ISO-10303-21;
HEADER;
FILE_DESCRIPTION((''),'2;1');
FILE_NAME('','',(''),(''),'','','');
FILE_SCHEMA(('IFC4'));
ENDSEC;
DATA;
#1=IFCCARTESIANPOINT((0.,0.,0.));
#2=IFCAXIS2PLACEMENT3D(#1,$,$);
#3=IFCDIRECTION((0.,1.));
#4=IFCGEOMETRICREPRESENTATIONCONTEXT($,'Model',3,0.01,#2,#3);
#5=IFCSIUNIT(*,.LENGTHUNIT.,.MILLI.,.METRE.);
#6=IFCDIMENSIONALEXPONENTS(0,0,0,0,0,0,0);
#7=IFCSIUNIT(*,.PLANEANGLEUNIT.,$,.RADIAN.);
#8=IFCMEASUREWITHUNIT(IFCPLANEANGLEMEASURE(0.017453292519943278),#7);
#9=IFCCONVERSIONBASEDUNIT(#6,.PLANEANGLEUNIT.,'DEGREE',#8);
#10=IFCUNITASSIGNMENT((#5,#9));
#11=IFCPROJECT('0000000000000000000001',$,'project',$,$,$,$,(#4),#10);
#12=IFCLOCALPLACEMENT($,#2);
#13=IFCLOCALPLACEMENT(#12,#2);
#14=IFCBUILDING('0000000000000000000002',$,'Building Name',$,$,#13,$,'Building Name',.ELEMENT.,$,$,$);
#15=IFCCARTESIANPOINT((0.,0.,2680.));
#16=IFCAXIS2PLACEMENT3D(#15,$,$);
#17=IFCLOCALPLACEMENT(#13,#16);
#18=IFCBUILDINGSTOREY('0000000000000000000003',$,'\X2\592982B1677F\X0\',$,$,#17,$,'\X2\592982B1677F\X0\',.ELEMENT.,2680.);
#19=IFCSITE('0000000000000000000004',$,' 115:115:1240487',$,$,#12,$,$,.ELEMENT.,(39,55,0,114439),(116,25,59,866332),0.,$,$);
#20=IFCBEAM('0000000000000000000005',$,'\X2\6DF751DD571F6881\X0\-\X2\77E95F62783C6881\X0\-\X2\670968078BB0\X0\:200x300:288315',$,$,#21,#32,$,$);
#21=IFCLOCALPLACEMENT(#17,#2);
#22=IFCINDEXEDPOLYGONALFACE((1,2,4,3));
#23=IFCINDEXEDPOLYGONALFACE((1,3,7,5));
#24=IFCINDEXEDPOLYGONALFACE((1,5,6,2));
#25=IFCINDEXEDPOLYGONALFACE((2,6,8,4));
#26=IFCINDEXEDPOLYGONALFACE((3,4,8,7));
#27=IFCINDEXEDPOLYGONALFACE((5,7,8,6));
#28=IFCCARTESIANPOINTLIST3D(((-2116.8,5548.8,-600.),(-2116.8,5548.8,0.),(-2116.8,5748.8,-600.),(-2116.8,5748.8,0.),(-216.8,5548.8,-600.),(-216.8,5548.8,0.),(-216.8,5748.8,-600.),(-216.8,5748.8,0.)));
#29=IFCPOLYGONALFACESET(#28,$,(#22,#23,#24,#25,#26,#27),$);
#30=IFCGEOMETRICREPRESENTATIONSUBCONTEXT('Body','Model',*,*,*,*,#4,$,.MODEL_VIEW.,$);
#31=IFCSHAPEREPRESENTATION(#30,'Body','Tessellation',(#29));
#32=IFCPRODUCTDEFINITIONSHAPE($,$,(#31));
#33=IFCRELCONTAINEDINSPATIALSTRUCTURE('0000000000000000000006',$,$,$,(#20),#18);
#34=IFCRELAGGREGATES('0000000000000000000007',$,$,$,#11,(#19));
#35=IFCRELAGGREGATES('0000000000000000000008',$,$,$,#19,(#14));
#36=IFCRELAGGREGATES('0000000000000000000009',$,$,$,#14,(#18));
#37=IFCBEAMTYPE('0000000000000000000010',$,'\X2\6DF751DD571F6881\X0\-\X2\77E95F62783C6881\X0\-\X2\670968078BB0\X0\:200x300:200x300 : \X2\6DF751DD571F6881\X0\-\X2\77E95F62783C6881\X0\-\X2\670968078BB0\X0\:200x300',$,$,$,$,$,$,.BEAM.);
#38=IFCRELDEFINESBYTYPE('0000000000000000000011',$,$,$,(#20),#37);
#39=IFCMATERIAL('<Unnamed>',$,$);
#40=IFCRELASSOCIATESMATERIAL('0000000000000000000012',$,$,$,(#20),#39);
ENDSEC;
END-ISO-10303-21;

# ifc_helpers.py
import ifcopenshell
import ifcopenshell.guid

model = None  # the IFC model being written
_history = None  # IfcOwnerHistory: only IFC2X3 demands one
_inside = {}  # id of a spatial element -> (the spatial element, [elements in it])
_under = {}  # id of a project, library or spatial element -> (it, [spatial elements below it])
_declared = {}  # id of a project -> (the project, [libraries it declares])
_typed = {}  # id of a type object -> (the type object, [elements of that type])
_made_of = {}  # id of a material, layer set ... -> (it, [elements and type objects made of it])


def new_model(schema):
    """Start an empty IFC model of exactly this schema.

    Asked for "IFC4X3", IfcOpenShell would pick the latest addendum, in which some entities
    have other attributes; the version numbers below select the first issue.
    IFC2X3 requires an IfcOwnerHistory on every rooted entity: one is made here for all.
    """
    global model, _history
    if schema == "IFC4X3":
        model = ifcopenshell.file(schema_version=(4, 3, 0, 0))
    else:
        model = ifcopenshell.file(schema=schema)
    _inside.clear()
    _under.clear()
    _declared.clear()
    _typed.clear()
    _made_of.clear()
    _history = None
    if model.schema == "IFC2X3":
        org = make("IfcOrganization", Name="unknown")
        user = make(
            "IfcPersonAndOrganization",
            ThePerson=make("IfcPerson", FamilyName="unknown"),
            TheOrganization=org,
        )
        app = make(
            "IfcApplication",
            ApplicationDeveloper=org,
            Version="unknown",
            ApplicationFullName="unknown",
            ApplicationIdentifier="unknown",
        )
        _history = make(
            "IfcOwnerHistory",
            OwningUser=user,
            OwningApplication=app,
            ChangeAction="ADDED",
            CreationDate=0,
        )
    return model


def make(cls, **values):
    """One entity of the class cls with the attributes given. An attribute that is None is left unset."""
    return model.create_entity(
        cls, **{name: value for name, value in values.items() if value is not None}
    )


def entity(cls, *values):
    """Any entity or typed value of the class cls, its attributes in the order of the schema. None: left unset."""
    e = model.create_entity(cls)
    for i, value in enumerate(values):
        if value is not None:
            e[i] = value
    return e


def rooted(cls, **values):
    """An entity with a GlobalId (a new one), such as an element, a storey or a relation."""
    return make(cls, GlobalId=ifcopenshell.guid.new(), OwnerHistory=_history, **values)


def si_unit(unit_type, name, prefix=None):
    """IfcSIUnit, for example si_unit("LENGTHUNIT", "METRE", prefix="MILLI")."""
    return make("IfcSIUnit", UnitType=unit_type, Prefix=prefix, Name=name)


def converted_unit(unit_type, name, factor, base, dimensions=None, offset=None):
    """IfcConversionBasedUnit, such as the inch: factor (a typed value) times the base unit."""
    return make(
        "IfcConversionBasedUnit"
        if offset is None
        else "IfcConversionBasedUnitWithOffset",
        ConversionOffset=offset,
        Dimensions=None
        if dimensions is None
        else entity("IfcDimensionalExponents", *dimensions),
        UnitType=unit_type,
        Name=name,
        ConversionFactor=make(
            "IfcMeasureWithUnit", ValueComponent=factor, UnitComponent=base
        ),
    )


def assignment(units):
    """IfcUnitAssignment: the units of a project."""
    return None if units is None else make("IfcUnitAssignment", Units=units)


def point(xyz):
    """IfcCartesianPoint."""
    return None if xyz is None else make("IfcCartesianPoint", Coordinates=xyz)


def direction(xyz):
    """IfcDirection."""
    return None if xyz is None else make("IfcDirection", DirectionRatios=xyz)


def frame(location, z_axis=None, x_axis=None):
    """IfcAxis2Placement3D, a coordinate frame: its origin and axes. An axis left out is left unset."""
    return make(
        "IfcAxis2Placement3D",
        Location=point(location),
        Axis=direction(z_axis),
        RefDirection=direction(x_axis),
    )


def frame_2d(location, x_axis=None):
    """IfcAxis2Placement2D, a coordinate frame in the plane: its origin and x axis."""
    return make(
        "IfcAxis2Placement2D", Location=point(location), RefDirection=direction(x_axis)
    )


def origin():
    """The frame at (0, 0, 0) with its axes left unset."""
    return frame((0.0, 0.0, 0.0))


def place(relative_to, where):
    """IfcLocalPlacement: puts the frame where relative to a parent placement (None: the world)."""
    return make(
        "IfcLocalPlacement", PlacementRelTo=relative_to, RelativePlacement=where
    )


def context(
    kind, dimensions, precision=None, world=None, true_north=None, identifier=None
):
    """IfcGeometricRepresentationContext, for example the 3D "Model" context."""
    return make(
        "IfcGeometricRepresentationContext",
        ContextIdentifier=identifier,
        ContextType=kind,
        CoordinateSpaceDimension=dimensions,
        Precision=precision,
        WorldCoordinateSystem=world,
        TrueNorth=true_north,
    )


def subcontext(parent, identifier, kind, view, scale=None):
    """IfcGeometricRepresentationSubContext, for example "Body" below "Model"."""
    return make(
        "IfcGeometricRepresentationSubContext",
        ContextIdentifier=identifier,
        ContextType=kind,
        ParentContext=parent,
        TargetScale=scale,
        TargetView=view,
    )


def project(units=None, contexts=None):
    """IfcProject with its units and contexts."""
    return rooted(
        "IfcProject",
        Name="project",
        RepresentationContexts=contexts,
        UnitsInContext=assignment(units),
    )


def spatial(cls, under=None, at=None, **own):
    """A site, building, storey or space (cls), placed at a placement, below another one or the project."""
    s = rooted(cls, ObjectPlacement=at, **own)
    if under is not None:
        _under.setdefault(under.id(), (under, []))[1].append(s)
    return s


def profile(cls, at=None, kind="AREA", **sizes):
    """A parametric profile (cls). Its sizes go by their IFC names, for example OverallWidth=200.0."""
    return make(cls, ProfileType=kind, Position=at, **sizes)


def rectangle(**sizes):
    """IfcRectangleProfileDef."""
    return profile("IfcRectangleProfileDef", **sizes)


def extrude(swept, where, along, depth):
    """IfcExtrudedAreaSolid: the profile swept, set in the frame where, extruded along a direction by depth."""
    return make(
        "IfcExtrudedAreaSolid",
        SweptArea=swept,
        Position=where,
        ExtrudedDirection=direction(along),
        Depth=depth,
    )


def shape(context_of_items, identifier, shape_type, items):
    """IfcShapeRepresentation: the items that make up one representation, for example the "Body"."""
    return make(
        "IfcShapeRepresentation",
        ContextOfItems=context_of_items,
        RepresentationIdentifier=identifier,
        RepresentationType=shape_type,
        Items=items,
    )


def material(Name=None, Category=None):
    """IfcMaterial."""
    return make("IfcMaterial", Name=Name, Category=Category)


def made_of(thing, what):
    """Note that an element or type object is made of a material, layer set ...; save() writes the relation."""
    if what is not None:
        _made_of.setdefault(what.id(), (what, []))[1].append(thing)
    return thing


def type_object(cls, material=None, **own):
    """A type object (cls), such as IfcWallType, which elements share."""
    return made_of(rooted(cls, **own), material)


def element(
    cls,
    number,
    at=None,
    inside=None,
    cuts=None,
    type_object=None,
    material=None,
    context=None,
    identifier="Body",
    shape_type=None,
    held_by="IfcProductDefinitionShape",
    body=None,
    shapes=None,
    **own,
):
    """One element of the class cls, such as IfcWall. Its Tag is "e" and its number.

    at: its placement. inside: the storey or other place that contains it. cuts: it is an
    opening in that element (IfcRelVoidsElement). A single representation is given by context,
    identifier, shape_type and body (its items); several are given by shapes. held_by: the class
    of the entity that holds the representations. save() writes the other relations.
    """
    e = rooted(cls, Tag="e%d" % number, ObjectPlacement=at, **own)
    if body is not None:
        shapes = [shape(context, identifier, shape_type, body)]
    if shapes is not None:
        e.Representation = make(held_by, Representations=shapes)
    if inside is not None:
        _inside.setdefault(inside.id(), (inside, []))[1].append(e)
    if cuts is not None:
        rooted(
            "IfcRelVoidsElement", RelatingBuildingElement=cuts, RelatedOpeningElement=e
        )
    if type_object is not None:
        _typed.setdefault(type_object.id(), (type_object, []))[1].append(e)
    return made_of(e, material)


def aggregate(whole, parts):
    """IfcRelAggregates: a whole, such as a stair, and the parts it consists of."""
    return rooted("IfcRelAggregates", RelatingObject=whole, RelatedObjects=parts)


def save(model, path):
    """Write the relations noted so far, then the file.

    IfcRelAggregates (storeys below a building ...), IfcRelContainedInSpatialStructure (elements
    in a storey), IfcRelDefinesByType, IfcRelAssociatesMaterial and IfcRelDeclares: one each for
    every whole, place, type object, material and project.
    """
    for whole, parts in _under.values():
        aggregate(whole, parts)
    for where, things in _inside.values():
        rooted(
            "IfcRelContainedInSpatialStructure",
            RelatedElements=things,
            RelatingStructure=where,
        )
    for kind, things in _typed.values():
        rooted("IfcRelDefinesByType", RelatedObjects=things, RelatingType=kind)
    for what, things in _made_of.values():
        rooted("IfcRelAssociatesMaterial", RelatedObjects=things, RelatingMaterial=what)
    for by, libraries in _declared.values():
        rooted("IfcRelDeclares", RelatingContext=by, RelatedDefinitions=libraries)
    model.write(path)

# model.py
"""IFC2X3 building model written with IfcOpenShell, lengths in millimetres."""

from ifc_helpers import new_model, entity, si_unit, converted_unit, direction, frame, frame_2d, origin, place, context, subcontext, project, spatial, rectangle, extrude, material, type_object, element, save


model = new_model("IFC2X3")

# Units and contexts
model_context = context("Model", 3, precision=0.01, world=origin(), true_north=direction((0.0, 1.0)))
body_context = subcontext(model_context, "Body", "Model", "MODEL_VIEW")
ifc_project = project(units=[si_unit("LENGTHUNIT", "METRE", prefix="MILLI"), converted_unit("PLANEANGLEUNIT", "DEGREE", entity("IfcPlaneAngleMeasure", 0.017453292519943278), si_unit("PLANEANGLEUNIT", "RADIAN"), dimensions=[0, 0, 0, 0, 0, 0, 0])], contexts=[model_context])

# Site, building, storey
site_placement = place(None, origin())
site = spatial("IfcSite", under=ifc_project, at=site_placement, Name=" 115:115:1240487", CompositionType="ELEMENT", RefLatitude=(39, 55, 0, 114439), RefLongitude=(116, 25, 59, 866332), RefElevation=0.0)
building_placement = place(site_placement, origin())
building = spatial("IfcBuilding", under=site, at=building_placement, Name="Building Name", LongName="Building Name", CompositionType="ELEMENT")
storey_placement = place(building_placement, frame((0.0, 0.0, 2680.0)))
storey = spatial("IfcBuildingStorey", under=building, at=storey_placement, Name="天花板", LongName="天花板", CompositionType="ELEMENT", Elevation=2680.0)

# Beam
ifc_material_1 = material(Name="<Unnamed>")
beam_type = type_object("IfcBeamType", Name="混凝土梁-矩形砼梁-有标记:200x300:200x300 : 混凝土梁-矩形砼梁-有标记:200x300", PredefinedType="BEAM")
beam_placement = place(storey_placement, origin())
element("IfcBeam", 1, at=beam_placement, inside=storey, type_object=beam_type, material=ifc_material_1, Name="混凝土梁-矩形砼梁-有标记:200x300:288315", context=body_context, shape_type="SweptSolid", body=[
    extrude(rectangle(XDim=600.0, YDim=200.0, at=frame_2d((0.0, 0.0), x_axis=(0.0, 1.0))), frame((-2116.8, 5648.8, -300.0), z_axis=(1.0, 0.0, 0.0), x_axis=(0.0, 1.0, 0.0)), (0.0, 0.0, 1.0), 1900.0),
])

save(model, "model.ifc")
